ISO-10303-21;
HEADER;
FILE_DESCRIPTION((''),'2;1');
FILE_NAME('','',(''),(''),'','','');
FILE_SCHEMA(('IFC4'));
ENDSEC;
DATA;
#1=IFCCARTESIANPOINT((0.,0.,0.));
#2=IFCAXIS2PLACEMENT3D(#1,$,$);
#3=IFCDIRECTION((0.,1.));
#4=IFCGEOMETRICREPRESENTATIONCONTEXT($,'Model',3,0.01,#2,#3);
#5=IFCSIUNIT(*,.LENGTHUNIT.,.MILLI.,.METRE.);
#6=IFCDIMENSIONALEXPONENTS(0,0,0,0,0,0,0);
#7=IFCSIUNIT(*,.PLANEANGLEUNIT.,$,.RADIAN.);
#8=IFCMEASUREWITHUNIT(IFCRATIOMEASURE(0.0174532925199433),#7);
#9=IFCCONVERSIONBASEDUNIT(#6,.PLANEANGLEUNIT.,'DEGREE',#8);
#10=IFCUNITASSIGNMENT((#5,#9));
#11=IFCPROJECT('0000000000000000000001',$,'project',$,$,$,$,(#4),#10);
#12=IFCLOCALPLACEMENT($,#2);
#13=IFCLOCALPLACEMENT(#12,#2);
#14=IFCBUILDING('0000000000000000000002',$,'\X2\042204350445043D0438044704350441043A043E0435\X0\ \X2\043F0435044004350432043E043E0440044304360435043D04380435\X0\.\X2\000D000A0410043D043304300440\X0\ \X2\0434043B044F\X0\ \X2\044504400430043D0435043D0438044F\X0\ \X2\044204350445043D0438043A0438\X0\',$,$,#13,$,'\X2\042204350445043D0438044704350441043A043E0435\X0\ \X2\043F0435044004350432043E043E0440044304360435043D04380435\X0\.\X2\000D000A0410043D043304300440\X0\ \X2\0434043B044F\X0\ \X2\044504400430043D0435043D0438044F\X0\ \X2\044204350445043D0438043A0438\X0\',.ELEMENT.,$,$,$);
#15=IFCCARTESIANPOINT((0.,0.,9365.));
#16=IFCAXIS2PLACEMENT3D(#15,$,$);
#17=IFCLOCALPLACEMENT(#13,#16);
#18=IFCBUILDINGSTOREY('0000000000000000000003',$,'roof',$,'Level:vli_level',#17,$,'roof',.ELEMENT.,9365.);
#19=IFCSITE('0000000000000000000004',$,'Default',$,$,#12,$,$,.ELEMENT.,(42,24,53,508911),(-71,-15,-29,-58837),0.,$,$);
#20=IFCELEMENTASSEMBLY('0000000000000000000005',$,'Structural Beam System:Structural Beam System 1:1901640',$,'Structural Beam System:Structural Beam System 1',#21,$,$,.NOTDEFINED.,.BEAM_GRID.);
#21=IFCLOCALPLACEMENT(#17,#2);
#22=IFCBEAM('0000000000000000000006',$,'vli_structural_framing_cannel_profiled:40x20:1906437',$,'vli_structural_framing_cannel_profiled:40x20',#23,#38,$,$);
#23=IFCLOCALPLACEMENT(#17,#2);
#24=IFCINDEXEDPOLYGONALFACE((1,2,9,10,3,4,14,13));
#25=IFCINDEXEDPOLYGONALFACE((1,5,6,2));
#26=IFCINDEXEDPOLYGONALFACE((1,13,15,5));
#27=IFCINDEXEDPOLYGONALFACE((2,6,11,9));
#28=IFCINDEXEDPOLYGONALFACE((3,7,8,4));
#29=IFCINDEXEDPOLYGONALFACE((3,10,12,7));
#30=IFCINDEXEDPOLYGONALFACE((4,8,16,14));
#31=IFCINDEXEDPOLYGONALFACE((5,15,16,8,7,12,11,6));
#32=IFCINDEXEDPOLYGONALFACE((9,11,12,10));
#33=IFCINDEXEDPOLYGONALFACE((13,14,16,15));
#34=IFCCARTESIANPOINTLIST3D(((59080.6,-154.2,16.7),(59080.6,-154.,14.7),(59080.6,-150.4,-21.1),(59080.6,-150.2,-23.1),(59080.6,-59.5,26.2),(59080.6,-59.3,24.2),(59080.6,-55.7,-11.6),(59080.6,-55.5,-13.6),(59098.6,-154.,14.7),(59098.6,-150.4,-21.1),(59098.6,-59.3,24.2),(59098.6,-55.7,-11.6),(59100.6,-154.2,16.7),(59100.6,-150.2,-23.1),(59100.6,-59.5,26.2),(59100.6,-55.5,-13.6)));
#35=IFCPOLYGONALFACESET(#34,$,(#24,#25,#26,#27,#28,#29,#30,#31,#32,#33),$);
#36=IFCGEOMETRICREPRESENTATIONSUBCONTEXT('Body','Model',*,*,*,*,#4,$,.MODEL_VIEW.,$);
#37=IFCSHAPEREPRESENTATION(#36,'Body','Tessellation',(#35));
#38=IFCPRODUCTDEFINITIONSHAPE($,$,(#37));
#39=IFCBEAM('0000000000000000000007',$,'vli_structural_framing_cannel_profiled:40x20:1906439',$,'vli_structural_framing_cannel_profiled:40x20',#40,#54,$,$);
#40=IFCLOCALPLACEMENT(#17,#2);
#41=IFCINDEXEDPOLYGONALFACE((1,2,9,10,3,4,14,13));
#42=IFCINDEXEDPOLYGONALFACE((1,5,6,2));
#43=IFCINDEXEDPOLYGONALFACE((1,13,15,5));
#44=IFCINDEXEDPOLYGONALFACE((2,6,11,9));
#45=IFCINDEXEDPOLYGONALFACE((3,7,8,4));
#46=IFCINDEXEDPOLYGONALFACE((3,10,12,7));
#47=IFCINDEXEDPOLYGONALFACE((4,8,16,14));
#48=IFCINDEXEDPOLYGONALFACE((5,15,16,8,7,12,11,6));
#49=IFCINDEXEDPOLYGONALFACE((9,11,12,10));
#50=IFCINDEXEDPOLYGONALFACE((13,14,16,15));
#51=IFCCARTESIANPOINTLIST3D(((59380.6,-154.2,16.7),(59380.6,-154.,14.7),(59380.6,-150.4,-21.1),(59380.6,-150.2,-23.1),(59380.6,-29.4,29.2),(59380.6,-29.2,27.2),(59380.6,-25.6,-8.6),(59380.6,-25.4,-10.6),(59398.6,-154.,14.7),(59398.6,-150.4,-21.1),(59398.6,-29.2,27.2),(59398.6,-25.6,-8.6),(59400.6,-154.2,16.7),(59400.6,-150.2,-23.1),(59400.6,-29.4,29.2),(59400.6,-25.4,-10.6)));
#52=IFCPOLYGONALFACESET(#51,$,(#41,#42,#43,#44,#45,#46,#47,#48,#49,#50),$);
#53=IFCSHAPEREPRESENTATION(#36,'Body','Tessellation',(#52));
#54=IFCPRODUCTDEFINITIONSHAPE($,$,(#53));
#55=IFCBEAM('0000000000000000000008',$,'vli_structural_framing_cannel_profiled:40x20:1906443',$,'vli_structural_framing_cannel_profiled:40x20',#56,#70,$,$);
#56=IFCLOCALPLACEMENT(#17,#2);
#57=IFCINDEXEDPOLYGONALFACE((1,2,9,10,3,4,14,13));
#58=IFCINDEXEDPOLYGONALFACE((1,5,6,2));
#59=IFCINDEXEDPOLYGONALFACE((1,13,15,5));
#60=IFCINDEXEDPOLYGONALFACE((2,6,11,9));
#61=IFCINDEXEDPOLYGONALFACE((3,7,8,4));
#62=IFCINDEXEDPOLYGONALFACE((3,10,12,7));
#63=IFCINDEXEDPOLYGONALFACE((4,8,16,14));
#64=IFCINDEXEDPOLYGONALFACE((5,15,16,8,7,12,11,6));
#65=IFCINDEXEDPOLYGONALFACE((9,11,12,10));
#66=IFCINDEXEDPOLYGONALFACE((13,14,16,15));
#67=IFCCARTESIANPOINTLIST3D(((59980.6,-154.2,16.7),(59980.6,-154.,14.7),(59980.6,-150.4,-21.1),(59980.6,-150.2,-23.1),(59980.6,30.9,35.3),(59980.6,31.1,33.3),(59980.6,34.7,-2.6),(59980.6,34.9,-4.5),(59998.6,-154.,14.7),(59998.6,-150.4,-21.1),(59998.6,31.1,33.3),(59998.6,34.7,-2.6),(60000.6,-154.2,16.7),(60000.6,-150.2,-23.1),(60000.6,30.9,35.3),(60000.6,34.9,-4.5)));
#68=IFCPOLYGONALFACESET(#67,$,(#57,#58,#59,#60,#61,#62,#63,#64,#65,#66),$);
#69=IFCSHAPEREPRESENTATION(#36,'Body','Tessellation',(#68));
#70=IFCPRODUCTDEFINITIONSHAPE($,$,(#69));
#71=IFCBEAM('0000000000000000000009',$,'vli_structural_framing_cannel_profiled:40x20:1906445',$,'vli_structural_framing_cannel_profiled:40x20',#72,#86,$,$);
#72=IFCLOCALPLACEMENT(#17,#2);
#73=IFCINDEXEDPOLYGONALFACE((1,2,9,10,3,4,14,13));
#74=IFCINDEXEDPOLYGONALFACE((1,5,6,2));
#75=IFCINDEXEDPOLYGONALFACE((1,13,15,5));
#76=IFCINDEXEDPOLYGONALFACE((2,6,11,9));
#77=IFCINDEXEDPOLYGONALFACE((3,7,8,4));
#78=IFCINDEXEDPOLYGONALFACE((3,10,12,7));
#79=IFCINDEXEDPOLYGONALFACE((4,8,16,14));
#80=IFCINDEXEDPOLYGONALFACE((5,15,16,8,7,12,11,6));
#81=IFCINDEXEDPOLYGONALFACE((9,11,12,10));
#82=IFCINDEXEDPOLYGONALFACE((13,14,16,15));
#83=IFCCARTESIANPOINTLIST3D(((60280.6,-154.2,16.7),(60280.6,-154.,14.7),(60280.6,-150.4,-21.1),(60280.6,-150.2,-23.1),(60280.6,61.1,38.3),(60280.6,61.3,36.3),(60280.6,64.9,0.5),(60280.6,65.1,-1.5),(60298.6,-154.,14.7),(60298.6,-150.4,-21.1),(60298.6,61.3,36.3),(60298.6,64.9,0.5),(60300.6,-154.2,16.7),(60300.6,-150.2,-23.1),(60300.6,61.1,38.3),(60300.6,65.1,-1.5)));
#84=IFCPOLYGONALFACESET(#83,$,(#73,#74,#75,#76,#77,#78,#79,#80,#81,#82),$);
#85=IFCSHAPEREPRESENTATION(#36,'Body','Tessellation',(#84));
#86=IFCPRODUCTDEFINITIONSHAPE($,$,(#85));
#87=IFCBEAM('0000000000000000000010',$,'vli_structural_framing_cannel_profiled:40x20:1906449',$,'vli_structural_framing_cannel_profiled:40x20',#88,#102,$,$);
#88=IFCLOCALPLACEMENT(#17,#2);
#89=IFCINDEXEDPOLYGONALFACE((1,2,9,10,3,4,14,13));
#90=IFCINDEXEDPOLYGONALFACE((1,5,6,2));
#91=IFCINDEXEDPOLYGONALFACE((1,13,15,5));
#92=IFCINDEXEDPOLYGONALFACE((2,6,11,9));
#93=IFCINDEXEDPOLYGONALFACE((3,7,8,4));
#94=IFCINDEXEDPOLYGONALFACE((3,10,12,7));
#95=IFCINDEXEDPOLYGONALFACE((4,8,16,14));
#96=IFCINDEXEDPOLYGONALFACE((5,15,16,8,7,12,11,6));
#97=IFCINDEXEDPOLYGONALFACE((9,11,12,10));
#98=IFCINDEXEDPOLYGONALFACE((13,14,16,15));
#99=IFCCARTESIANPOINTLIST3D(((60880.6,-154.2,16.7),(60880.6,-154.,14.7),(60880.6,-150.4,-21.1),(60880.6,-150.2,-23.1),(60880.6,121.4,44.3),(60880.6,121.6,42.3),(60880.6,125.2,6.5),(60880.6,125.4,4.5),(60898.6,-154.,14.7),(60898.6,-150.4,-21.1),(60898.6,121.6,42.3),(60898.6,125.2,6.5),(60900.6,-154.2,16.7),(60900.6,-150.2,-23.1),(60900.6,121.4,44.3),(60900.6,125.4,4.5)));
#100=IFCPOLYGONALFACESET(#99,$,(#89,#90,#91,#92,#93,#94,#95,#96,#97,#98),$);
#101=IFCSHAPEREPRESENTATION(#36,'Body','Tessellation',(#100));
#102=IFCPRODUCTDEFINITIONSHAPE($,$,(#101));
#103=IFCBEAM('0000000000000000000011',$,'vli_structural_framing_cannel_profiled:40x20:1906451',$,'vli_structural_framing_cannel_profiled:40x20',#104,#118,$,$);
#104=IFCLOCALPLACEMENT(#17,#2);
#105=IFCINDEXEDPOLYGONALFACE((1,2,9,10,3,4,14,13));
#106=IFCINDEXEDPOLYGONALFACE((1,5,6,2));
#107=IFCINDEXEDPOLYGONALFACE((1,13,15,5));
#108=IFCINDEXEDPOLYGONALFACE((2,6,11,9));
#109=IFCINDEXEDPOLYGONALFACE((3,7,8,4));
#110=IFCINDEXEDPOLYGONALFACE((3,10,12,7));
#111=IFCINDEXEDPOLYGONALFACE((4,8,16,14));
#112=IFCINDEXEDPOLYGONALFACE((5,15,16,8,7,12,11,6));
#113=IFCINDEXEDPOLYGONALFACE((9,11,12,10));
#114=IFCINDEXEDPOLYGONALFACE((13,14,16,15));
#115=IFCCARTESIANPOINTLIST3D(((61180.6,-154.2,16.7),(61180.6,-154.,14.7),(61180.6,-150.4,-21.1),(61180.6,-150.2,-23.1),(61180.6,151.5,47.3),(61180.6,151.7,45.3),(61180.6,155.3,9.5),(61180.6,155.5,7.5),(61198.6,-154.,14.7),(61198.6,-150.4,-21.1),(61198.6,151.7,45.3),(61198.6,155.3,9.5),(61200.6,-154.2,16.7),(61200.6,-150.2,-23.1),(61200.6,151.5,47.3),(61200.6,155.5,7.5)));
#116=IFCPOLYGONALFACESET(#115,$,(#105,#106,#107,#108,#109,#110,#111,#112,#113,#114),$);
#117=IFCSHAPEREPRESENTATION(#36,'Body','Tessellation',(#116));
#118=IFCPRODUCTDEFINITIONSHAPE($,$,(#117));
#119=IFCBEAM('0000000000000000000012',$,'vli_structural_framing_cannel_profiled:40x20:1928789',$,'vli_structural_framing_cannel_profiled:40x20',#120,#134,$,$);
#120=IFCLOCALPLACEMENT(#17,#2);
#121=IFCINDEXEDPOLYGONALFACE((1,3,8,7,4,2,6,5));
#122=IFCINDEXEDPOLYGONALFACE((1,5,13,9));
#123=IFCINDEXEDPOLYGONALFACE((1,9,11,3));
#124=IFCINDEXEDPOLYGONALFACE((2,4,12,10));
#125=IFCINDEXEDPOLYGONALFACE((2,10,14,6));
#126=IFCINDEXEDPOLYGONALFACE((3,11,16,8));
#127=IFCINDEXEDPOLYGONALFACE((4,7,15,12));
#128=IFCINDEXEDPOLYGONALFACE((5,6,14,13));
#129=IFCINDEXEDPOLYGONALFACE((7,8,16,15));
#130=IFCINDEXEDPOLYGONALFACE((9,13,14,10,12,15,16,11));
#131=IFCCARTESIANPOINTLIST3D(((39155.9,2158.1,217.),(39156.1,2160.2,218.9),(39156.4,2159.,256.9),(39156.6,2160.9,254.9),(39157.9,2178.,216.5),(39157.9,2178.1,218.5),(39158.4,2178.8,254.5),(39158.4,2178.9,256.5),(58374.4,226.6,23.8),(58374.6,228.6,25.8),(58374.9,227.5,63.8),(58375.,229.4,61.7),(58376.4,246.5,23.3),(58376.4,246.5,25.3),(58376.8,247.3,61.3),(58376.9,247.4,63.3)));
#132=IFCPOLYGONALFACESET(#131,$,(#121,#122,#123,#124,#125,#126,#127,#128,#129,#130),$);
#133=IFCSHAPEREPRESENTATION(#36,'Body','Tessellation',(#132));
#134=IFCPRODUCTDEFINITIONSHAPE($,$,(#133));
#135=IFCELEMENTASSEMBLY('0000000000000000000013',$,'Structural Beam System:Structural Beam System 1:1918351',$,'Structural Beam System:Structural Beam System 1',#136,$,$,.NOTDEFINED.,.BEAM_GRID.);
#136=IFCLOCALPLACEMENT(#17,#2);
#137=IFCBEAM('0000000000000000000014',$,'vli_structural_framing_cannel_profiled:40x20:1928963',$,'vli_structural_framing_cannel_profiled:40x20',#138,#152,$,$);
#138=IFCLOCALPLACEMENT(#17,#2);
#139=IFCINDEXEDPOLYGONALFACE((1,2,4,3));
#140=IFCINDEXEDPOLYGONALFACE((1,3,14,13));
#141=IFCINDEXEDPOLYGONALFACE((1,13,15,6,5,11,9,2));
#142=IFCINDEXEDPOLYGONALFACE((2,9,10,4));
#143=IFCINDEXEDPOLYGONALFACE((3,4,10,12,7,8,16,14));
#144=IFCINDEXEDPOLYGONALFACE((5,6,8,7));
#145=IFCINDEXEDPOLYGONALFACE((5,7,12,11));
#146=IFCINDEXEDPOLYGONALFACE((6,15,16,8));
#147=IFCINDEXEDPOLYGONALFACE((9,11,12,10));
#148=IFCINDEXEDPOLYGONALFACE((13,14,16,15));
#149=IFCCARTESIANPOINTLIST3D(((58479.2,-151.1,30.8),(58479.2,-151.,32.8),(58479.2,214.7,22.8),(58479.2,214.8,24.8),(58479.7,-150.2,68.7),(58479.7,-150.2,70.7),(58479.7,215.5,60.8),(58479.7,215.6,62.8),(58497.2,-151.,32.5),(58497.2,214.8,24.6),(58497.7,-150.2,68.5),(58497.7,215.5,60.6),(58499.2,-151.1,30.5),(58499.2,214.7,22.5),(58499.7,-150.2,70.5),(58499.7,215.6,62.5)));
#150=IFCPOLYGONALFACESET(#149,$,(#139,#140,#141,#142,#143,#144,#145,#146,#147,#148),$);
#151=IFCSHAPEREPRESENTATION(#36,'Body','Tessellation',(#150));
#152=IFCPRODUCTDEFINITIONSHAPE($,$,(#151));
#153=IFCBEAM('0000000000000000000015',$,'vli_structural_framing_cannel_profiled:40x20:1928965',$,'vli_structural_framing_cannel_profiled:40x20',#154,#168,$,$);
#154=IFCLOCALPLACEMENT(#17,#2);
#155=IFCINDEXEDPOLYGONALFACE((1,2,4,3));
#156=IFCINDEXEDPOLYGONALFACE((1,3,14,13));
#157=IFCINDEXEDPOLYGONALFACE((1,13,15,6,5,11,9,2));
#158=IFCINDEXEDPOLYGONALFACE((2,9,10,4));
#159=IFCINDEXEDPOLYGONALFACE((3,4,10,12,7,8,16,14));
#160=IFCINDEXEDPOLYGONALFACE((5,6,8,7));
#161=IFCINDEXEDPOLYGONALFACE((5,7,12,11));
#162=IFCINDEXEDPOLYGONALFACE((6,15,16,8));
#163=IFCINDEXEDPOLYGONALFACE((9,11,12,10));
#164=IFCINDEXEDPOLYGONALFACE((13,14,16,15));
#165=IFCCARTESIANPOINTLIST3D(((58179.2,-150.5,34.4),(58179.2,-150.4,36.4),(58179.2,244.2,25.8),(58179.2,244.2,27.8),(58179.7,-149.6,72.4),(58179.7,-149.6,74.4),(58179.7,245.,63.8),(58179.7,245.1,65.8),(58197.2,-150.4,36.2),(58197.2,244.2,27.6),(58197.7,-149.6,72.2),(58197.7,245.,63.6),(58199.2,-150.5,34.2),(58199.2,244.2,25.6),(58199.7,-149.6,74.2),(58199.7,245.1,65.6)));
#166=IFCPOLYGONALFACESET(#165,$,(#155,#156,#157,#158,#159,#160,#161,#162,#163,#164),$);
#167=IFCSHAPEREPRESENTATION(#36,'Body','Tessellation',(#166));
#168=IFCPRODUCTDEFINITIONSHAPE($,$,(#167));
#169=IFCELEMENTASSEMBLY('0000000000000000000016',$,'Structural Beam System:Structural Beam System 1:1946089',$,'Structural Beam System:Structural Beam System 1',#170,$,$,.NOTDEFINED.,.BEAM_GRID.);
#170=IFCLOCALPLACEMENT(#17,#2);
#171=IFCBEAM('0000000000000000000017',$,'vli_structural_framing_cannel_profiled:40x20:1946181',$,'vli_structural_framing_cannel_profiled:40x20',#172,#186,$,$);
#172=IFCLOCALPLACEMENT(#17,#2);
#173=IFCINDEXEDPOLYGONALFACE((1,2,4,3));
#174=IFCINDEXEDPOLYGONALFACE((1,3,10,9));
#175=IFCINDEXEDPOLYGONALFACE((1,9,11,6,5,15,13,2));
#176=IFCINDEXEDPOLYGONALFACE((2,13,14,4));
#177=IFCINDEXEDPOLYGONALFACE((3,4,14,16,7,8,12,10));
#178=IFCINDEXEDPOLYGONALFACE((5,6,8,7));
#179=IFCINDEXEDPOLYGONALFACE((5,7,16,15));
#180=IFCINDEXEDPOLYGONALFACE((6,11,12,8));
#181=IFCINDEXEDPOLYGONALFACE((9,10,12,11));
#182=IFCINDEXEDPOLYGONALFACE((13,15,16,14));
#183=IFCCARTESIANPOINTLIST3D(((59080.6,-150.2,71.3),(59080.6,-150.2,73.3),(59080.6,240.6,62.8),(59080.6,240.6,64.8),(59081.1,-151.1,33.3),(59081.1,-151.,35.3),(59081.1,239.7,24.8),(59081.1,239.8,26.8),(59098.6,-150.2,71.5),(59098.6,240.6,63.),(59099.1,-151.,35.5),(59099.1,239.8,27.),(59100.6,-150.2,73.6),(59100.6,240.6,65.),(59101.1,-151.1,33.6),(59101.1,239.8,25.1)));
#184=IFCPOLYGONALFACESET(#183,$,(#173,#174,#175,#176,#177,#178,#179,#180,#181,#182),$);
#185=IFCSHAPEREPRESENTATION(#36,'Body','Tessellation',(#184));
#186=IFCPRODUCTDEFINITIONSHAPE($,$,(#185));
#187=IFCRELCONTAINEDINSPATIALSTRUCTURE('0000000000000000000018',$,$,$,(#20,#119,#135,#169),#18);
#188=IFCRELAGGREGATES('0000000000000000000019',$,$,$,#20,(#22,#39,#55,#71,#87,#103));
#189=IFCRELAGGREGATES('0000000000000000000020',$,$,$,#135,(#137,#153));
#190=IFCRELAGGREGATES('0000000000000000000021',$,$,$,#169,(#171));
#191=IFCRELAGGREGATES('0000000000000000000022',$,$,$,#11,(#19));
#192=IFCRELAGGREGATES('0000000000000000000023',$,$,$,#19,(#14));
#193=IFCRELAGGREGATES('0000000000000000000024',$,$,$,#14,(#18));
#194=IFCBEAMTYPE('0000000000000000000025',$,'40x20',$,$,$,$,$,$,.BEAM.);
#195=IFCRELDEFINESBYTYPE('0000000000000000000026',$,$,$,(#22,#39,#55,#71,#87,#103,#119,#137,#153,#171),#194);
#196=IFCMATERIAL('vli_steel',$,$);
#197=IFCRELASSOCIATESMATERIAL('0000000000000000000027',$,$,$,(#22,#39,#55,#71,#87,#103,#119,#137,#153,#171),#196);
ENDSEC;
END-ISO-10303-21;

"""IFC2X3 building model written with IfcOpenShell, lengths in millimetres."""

from ifc_helpers import new_model, entity, si_unit, converted_unit, direction, frame, origin, place, context, subcontext, project, spatial, polyline, outline, extrude, material, type_object, element, aggregate, save


model = new_model("IFC2X3")

# Units and contexts
model_context = context("Model", 3, precision=0.01, world=origin(), true_north=direction((0.0, 1.0)))
body_context = subcontext(model_context, "Body", "Model", "MODEL_VIEW")
ifc_project = project(units=[si_unit("LENGTHUNIT", "METRE", prefix="MILLI"), converted_unit("PLANEANGLEUNIT", "DEGREE", entity("IfcRatioMeasure", 0.0174532925199433), si_unit("PLANEANGLEUNIT", "RADIAN"), dimensions=[0, 0, 0, 0, 0, 0, 0])], contexts=[model_context])

# Site, building, storey
site_placement = place(None, origin())
site = spatial("IfcSite", under=ifc_project, at=site_placement, Name="Default", CompositionType="ELEMENT", RefLatitude=(42, 24, 53, 508911), RefLongitude=(-71, -15, -29, -58837), RefElevation=0.0)
building_placement = place(site_placement, origin())
building = spatial("IfcBuilding", under=site, at=building_placement, Name="Техническое перевооружение.\r\nАнгар для хранения техники", LongName="Техническое перевооружение.\r\nАнгар для хранения техники", CompositionType="ELEMENT")
storey_placement = place(building_placement, frame((0.0, 0.0, 9365.0)))
storey = spatial("IfcBuildingStorey", under=building, at=storey_placement, Name="roof", ObjectType="Level:vli_level", LongName="roof", CompositionType="ELEMENT", Elevation=9365.0)

# Element assembly, beams
assembly_1_placement = place(storey_placement, origin())
assembly_1 = element("IfcElementAssembly", 1, at=assembly_1_placement, inside=storey, Name="Structural Beam System:Structural Beam System 1:1901640", ObjectType="Structural Beam System:Structural Beam System 1", AssemblyPlace="NOTDEFINED", PredefinedType="BEAM_GRID")
ifc_material = material(Name="vli_steel")
beam_type = type_object("IfcBeamType", Name="40x20", PredefinedType="BEAM")
beam_1_placement = place(assembly_1_placement, frame((59100.0, -55.5, -13.6), z_axis=(0.0, -0.099504, 0.995037), x_axis=(0.0, -0.995037, -0.099504)))
beam_1 = element("IfcBeam", 2, at=beam_1_placement, type_object=beam_type, material=ifc_material, Name="vli_structural_framing_cannel_profiled:40x20:1906437", ObjectType="vli_structural_framing_cannel_profiled:40x20", context=body_context, shape_type="SweptSolid", body=[
    extrude(outline(polyline([(-20.0, -9.5), (-18.0, -9.5), (-18.0, 8.5), (18.0, 8.5), (18.0, -9.5), (20.0, -9.5), (20.0, 10.5), (-20.0, 10.5), (-20.0, -9.5)])), frame((0.0, -9.9, 20.0), z_axis=(1.0, 0.0, 0.0), x_axis=(0.0, 0.0, -1.0)), (0.0, 0.0, 1.0), 95.2),
])
beam_2_placement = place(assembly_1_placement, frame((59400.0, -25.4, -10.6), z_axis=(0.0, -0.099504, 0.995037), x_axis=(0.0, -0.995037, -0.099504)))
beam_2 = element("IfcBeam", 3, at=beam_2_placement, type_object=beam_type, material=ifc_material, Name="vli_structural_framing_cannel_profiled:40x20:1906439", ObjectType="vli_structural_framing_cannel_profiled:40x20", context=body_context, shape_type="SweptSolid", body=[
    extrude(outline(polyline([(-20.0, -9.5), (-18.0, -9.5), (-18.0, 8.5), (18.0, 8.5), (18.0, -9.5), (20.0, -9.5), (20.0, 10.5), (-20.0, 10.5), (-20.0, -9.5)])), frame((0.0, -9.9, 20.0), z_axis=(1.0, 0.0, 0.0), x_axis=(0.0, 0.0, -1.0)), (0.0, 0.0, 1.0), 125.5),
])
beam_3_placement = place(assembly_1_placement, frame((60000.0, 34.9, -4.5), z_axis=(0.0, -0.099504, 0.995037), x_axis=(0.0, -0.995037, -0.099504)))
beam_3 = element("IfcBeam", 4, at=beam_3_placement, type_object=beam_type, material=ifc_material, Name="vli_structural_framing_cannel_profiled:40x20:1906443", ObjectType="vli_structural_framing_cannel_profiled:40x20", context=body_context, shape_type="SweptSolid", body=[
    extrude(outline(polyline([(-20.0, -9.5), (-18.0, -9.5), (-18.0, 8.5), (18.0, 8.5), (18.0, -9.5), (20.0, -9.5), (20.0, 10.5), (-20.0, 10.5), (-20.0, -9.5)])), frame((0.0, -9.9, 20.0), z_axis=(1.0, 0.0, 0.0), x_axis=(0.0, 0.0, -1.0)), (0.0, 0.0, 1.0), 186.1),
])
beam_4_placement = place(assembly_1_placement, frame((60300.0, 65.1, -1.5), z_axis=(0.0, -0.099504, 0.995037), x_axis=(0.0, -0.995037, -0.099504)))
beam_4 = element("IfcBeam", 5, at=beam_4_placement, type_object=beam_type, material=ifc_material, Name="vli_structural_framing_cannel_profiled:40x20:1906445", ObjectType="vli_structural_framing_cannel_profiled:40x20", context=body_context, shape_type="SweptSolid", body=[
    extrude(outline(polyline([(-20.0, -9.5), (-18.0, -9.5), (-18.0, 8.5), (18.0, 8.5), (18.0, -9.5), (20.0, -9.5), (20.0, 10.5), (-20.0, 10.5), (-20.0, -9.5)])), frame((0.0, -9.9, 20.0), z_axis=(1.0, 0.0, 0.0), x_axis=(0.0, 0.0, -1.0)), (0.0, 0.0, 1.0), 216.4),
])
beam_5_placement = place(assembly_1_placement, frame((60900.0, 125.4, 4.5), z_axis=(0.0, -0.099504, 0.995037), x_axis=(0.0, -0.995037, -0.099504)))
beam_5 = element("IfcBeam", 6, at=beam_5_placement, type_object=beam_type, material=ifc_material, Name="vli_structural_framing_cannel_profiled:40x20:1906449", ObjectType="vli_structural_framing_cannel_profiled:40x20", context=body_context, shape_type="SweptSolid", body=[
    extrude(outline(polyline([(-20.0, -9.5), (-18.0, -9.5), (-18.0, 8.5), (18.0, 8.5), (18.0, -9.5), (20.0, -9.5), (20.0, 10.5), (-20.0, 10.5), (-20.0, -9.5)])), frame((0.0, -9.9, 20.0), z_axis=(1.0, 0.0, 0.0), x_axis=(0.0, 0.0, -1.0)), (0.0, 0.0, 1.0), 277.0),
])
beam_6_placement = place(assembly_1_placement, frame((61200.0, 155.5, 7.5), z_axis=(0.0, -0.099504, 0.995037), x_axis=(0.0, -0.995037, -0.099504)))
beam_6 = element("IfcBeam", 7, at=beam_6_placement, type_object=beam_type, material=ifc_material, Name="vli_structural_framing_cannel_profiled:40x20:1906451", ObjectType="vli_structural_framing_cannel_profiled:40x20", context=body_context, shape_type="SweptSolid", body=[
    extrude(outline(polyline([(-20.0, -9.5), (-18.0, -9.5), (-18.0, 8.5), (18.0, 8.5), (18.0, -9.5), (20.0, -9.5), (20.0, 10.5), (-20.0, 10.5), (-20.0, -9.5)])), frame((0.0, -9.9, 20.0), z_axis=(1.0, 0.0, 0.0), x_axis=(0.0, 0.0, -1.0)), (0.0, 0.0, 1.0), 307.3),
])
aggregate(assembly_1, [beam_1, beam_2, beam_3, beam_4, beam_5, beam_6])

# Beam
beam_7_placement = place(storey_placement, frame((58374.9, 228.1, 63.8), z_axis=(0.009949, -0.001, 0.99995), x_axis=(-0.994938, 0.099995, 0.01)))
element("IfcBeam", 8, at=beam_7_placement, inside=storey, type_object=beam_type, material=ifc_material, Name="vli_structural_framing_cannel_profiled:40x20:1928789", ObjectType="vli_structural_framing_cannel_profiled:40x20", context=body_context, shape_type="SweptSolid", body=[
    extrude(outline(polyline([(-10.5, -20.0), (9.5, -20.0), (9.5, -18.0), (-8.5, -18.0), (-8.5, 18.0), (9.5, 18.0), (9.5, 20.0), (-10.5, 20.0), (-10.5, -20.0)])), frame((0.0, -9.4, -20.2), z_axis=(1.0, 0.0, 0.0), x_axis=(0.0, -0.999738, -0.022906)), (0.0, 0.0, 1.0), 19316.3),
])

# Element assemblies, beams
assembly_2_placement = place(storey_placement, origin())
assembly_2 = element("IfcElementAssembly", 9, at=assembly_2_placement, inside=storey, Name="Structural Beam System:Structural Beam System 1:1918351", ObjectType="Structural Beam System:Structural Beam System 1", AssemblyPlace="NOTDEFINED", PredefinedType="BEAM_GRID")
beam_8_placement = place(assembly_2_placement, frame((58499.1, 215.6, 62.5), z_axis=(0.0, 0.02179, 0.999763), x_axis=(0.0, -0.999763, 0.02179)))
beam_8 = element("IfcBeam", 10, at=beam_8_placement, type_object=beam_type, material=ifc_material, Name="vli_structural_framing_cannel_profiled:40x20:1928963", ObjectType="vli_structural_framing_cannel_profiled:40x20", context=body_context, shape_type="SweptSolid", body=[
    extrude(outline(polyline([(-10.5, -20.0), (9.5, -20.0), (9.5, -18.0), (-8.5, -18.0), (-8.5, 18.0), (9.5, 18.0), (9.5, 20.0), (-10.5, 20.0), (-10.5, -20.0)])), frame((0.0, -10.1, -19.9), z_axis=(1.0, 0.0, 0.0), x_axis=(0.0, -0.999925, 0.012243)), (0.0, 0.0, 1.0), 365.9),
])
beam_9_placement = place(assembly_2_placement, frame((58199.1, 245.7, 65.5), z_axis=(0.0, 0.02179, 0.999763), x_axis=(0.0, -0.999763, 0.02179)))
beam_9 = element("IfcBeam", 11, at=beam_9_placement, type_object=beam_type, material=ifc_material, Name="vli_structural_framing_cannel_profiled:40x20:1928965", ObjectType="vli_structural_framing_cannel_profiled:40x20", context=body_context, shape_type="SweptSolid", body=[
    extrude(outline(polyline([(-10.5, -20.0), (9.5, -20.0), (9.5, -18.0), (-8.5, -18.0), (-8.5, 18.0), (9.5, 18.0), (9.5, 20.0), (-10.5, 20.0), (-10.5, -20.0)])), frame((0.7, -10.1, -19.9), z_axis=(1.0, 0.0, 0.0), x_axis=(0.0, -0.999925, 0.012243)), (0.0, 0.0, 1.0), 394.8),
])
aggregate(assembly_2, [beam_8, beam_9])
assembly_3_placement = place(storey_placement, origin())
assembly_3 = element("IfcElementAssembly", 12, at=assembly_3_placement, inside=storey, Name="Structural Beam System:Structural Beam System 1:1946089", ObjectType="Structural Beam System:Structural Beam System 1", AssemblyPlace="NOTDEFINED", PredefinedType="BEAM_GRID")
beam_10_placement = place(assembly_3_placement, frame((59100.0, 240.6, 65.0), z_axis=(0.0, 0.021775, 0.999763), x_axis=(0.0, -0.999763, 0.021775)))
beam_10 = element("IfcBeam", 13, at=beam_10_placement, type_object=beam_type, material=ifc_material, Name="vli_structural_framing_cannel_profiled:40x20:1946181", ObjectType="vli_structural_framing_cannel_profiled:40x20", context=body_context, shape_type="SweptSolid", body=[
    extrude(outline(polyline([(-10.5, -20.0), (9.5, -20.0), (9.5, -18.0), (-8.5, -18.0), (-8.5, 18.0), (9.5, 18.0), (9.5, 20.0), (-10.5, 20.0), (-10.5, -20.0)])), frame((0.0, -9.7, -20.1), z_axis=(1.0, 0.0, 0.0), x_axis=(0.0, -0.999925, -0.01227)), (0.0, 0.0, 1.0), 390.9),
])
aggregate(assembly_3, [beam_10])

save(model, "model.ifc")
